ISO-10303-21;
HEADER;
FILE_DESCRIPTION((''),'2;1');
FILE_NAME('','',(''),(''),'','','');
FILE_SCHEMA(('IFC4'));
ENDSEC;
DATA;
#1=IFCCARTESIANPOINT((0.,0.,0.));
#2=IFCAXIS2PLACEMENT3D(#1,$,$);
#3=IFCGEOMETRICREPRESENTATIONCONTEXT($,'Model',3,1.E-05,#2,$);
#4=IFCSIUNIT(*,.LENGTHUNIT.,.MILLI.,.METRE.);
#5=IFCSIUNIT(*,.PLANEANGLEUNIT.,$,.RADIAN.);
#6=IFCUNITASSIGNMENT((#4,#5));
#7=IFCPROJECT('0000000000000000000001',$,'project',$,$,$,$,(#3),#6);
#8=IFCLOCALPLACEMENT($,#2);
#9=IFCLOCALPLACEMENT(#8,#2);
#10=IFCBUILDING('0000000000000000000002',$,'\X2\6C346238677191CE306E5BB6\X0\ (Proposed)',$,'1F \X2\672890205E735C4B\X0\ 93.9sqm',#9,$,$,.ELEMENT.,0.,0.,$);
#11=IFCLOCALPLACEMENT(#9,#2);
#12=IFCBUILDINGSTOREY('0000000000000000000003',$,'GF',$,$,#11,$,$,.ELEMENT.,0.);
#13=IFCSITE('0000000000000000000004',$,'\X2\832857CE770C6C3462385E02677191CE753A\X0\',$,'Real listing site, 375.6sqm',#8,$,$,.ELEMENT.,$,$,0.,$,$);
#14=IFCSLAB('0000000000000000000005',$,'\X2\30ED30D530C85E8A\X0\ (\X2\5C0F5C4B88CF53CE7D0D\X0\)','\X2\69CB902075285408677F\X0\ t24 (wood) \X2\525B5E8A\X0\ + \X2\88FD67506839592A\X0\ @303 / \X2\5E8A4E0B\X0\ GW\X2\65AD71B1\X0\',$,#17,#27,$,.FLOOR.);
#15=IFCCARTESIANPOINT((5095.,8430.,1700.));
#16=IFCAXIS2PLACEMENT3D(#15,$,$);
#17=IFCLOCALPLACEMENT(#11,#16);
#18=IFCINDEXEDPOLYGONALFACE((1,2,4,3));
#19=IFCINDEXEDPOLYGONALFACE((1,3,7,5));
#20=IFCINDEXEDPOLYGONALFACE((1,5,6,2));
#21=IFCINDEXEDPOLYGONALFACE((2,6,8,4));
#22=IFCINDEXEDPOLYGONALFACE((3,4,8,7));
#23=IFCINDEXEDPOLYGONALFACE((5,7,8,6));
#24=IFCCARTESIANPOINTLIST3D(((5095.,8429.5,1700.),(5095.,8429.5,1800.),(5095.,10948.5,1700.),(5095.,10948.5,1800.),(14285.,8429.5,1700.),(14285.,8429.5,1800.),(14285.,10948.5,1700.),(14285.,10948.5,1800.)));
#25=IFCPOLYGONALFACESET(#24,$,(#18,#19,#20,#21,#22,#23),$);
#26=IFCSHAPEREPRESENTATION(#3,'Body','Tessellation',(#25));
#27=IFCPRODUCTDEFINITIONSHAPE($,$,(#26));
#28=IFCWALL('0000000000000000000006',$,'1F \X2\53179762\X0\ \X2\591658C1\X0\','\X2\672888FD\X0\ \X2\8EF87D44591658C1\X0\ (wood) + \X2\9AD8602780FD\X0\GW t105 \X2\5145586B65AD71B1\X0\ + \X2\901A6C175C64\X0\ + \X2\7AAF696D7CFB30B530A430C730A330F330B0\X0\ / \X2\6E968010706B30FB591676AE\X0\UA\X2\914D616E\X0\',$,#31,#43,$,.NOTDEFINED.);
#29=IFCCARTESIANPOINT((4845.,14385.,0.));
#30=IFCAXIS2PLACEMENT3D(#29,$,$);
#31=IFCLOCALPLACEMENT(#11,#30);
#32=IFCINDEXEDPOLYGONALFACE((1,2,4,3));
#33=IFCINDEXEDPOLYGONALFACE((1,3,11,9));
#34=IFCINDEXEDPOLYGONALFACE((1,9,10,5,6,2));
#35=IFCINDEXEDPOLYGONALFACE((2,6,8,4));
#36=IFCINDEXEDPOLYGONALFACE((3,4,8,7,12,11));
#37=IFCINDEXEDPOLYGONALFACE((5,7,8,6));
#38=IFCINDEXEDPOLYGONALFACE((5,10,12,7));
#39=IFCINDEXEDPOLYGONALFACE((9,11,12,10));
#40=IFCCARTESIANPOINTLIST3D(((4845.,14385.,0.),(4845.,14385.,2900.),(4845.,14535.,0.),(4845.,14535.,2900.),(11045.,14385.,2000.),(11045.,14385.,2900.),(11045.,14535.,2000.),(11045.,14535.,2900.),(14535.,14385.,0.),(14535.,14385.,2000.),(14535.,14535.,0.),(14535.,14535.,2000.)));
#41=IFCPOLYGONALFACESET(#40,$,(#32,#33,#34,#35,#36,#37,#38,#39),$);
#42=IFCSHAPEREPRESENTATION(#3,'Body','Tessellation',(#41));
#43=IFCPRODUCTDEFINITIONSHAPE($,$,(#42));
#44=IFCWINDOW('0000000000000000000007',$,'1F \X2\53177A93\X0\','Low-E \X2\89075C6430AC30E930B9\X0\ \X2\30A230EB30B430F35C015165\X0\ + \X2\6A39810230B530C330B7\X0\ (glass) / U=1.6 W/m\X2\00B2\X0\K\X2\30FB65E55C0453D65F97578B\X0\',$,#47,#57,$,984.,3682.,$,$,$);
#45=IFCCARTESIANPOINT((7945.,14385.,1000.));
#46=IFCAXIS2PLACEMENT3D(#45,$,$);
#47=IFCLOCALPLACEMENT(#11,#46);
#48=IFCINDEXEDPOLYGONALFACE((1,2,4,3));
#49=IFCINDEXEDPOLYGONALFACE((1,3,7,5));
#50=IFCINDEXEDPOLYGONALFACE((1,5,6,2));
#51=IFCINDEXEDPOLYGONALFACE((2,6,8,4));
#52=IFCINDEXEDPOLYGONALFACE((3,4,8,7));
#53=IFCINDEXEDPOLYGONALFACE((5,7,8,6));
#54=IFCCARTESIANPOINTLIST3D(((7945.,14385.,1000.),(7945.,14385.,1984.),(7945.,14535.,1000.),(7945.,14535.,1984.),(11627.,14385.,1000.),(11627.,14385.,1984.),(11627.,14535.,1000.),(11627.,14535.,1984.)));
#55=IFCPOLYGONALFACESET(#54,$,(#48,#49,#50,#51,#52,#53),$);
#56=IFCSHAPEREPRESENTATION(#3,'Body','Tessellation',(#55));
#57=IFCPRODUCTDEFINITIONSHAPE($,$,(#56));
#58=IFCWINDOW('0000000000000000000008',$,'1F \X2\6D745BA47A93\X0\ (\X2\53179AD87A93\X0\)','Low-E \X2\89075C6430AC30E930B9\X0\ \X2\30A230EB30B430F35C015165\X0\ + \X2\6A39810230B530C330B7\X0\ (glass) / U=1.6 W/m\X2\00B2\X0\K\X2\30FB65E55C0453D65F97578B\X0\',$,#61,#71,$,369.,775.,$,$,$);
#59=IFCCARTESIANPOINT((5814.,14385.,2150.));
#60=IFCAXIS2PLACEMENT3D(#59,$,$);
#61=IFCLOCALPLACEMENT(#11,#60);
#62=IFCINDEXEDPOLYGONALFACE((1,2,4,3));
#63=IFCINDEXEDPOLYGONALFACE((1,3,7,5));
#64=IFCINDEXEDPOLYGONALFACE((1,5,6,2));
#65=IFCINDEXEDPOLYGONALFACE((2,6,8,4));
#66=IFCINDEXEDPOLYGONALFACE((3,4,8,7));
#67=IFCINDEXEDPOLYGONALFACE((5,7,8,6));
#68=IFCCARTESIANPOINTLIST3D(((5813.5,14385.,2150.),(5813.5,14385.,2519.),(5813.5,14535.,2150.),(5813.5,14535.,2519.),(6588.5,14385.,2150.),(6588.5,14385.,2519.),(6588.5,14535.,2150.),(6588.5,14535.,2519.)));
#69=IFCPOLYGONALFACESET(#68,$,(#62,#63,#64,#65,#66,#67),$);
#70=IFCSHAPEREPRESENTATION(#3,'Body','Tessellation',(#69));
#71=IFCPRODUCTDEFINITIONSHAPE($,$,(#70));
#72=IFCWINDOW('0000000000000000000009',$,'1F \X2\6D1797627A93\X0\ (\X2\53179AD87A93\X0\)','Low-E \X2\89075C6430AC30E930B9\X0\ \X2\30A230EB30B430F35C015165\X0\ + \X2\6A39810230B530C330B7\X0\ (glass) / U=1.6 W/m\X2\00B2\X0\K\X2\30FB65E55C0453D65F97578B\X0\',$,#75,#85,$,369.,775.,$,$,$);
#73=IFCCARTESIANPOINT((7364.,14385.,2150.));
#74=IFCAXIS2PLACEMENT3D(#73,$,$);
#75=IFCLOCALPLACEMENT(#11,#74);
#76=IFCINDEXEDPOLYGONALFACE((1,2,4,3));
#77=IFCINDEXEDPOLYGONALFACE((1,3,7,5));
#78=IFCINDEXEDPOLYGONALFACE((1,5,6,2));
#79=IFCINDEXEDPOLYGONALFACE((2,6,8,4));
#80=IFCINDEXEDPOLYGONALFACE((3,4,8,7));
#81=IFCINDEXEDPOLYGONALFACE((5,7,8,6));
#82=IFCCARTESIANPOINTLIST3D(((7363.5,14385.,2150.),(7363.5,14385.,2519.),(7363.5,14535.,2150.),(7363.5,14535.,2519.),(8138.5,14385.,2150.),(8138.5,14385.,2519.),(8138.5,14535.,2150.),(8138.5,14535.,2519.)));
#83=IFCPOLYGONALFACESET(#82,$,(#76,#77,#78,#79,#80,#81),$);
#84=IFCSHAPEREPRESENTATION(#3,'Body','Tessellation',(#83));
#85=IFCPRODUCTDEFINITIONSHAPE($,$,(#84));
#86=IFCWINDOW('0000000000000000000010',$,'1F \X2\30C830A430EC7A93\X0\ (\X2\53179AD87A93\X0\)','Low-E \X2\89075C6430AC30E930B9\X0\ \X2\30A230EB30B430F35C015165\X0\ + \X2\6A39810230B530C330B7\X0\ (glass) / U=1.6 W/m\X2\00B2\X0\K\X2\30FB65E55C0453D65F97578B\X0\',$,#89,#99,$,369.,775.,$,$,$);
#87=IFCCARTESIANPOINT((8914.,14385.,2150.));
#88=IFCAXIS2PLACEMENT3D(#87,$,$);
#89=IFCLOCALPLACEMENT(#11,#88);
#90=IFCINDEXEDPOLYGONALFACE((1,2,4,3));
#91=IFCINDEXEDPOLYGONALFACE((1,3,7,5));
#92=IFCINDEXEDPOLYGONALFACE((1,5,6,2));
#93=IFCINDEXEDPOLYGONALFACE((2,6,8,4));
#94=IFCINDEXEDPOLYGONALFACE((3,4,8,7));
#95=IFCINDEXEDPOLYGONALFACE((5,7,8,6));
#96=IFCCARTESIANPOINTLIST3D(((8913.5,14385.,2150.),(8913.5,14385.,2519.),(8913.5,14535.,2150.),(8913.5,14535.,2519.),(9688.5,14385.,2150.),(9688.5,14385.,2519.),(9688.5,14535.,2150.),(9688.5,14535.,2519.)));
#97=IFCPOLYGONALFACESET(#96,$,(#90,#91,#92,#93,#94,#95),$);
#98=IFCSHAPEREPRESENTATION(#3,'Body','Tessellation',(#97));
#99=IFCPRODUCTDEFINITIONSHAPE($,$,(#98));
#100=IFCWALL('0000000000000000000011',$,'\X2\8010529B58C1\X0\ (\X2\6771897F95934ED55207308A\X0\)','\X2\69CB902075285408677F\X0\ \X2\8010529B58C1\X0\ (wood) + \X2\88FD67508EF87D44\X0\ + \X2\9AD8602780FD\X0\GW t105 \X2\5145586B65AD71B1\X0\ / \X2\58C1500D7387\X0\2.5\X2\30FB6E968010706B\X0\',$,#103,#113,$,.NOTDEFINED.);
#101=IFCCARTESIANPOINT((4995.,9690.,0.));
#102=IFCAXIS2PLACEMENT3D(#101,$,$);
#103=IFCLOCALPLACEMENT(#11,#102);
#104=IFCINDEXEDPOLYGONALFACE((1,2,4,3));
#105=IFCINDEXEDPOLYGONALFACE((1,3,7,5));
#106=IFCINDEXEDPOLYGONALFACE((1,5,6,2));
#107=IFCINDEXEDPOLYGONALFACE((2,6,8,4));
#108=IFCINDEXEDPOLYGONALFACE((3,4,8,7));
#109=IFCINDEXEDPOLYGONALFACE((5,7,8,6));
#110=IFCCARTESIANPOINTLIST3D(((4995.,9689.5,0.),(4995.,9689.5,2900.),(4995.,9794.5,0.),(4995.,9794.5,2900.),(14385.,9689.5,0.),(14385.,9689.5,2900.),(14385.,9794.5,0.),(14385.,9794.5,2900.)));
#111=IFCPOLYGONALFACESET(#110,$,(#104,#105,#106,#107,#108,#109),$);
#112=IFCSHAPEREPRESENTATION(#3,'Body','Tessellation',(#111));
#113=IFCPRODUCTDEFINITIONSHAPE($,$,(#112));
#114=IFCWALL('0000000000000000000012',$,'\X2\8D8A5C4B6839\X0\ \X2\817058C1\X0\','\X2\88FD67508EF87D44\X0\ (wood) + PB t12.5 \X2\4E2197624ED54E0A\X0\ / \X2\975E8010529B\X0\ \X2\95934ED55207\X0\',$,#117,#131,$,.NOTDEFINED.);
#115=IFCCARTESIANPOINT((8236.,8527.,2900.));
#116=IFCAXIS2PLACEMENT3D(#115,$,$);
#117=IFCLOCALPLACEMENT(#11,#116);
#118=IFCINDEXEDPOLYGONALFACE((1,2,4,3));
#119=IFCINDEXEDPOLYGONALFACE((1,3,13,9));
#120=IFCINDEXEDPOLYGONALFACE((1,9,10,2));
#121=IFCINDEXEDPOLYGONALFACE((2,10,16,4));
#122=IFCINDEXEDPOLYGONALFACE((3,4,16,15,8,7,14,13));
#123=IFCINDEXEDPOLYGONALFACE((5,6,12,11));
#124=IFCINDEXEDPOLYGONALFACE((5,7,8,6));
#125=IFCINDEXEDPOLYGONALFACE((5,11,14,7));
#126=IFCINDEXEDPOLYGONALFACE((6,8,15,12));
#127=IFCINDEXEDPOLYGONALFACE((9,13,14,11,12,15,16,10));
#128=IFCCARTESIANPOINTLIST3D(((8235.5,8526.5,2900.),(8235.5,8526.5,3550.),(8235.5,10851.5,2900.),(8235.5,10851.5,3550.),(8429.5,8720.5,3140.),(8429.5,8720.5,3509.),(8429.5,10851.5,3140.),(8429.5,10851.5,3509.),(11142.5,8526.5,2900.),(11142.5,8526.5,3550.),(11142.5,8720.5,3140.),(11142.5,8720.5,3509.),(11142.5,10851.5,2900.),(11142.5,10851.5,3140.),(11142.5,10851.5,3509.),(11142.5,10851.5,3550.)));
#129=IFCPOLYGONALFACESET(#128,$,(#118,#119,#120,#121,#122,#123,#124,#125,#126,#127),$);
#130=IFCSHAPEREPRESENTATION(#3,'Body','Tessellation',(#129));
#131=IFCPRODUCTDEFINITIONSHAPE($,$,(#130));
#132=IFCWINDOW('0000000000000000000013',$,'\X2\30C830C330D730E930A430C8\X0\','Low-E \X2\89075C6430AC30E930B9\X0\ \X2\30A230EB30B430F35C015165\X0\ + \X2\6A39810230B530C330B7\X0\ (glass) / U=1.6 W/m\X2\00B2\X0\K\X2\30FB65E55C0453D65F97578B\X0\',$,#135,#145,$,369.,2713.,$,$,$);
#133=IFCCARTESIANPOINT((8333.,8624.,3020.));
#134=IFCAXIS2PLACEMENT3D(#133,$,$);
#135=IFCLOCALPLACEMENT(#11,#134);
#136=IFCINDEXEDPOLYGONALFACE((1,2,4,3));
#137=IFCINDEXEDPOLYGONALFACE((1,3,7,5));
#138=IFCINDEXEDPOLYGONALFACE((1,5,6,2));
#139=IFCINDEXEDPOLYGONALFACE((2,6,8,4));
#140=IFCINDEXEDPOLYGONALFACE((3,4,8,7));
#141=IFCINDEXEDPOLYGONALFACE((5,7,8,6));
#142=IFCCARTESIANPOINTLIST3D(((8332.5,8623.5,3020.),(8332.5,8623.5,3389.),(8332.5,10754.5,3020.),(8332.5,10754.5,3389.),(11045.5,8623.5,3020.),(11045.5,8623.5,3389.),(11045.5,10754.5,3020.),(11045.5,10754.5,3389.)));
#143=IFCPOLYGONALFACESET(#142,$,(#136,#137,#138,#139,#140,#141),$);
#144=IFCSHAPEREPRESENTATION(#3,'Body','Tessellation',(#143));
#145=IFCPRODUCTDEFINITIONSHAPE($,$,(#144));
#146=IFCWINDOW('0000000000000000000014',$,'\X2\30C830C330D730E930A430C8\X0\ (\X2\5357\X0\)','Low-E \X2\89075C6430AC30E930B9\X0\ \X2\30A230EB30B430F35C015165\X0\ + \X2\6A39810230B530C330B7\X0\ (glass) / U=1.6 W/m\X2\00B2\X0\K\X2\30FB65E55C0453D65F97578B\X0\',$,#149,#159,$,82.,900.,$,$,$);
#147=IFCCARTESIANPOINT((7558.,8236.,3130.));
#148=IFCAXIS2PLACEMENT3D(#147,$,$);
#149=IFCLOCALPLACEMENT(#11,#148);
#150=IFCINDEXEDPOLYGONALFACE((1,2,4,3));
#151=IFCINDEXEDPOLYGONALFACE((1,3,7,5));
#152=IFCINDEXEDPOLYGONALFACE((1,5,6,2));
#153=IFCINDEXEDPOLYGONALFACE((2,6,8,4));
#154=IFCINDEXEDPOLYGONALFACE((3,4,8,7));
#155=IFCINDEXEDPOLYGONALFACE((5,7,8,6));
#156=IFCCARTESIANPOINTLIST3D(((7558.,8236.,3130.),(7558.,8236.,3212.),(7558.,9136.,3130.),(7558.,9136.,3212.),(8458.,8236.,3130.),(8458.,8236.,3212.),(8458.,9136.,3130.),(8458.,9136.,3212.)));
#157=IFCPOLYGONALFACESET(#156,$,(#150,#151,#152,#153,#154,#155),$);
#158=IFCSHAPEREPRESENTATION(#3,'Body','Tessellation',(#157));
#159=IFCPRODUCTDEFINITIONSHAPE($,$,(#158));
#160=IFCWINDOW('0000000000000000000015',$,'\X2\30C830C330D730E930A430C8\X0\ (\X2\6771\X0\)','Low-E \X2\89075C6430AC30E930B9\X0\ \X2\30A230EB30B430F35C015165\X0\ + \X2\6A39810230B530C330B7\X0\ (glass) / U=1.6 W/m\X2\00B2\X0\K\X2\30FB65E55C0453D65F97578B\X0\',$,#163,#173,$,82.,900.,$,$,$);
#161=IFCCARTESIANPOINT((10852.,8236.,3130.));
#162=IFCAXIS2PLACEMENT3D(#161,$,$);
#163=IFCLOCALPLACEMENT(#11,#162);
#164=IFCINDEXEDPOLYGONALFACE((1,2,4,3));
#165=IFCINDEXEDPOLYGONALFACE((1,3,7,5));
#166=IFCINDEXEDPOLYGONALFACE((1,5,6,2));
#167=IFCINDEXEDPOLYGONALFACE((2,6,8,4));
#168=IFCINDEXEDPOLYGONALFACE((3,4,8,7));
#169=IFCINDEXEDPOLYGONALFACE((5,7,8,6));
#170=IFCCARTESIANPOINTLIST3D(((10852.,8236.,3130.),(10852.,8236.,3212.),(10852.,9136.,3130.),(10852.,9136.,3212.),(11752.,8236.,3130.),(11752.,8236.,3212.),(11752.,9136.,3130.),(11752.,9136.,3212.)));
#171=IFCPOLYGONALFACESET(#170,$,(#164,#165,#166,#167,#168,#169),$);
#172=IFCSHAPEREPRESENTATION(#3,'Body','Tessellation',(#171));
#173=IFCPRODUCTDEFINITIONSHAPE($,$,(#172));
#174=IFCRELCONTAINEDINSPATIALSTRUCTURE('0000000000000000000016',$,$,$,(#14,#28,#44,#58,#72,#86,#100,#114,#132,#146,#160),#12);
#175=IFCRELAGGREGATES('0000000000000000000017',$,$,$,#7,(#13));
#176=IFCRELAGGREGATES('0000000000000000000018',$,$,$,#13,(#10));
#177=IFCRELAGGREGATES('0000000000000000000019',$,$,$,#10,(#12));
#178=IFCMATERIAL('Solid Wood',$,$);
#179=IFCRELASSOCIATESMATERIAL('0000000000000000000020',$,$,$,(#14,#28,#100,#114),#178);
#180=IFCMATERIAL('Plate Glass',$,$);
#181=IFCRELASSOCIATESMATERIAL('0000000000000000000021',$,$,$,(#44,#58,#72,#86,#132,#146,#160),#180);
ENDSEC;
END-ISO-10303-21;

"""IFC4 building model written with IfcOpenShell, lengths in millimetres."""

from ifc_helpers import new_model, si_unit, frame, frame_2d, origin, place, context, project, spatial, rectangle, extrude, material, element, fill, save


model = new_model("IFC4")

# Units and contexts
model_context = context("Model", 3, precision=1e-05, world=origin())
ifc_project = project(units=[si_unit("LENGTHUNIT", "METRE", prefix="MILLI"), si_unit("PLANEANGLEUNIT", "RADIAN")], contexts=[model_context])

# Site, building, storey
site_placement = place(None, origin())
site = spatial("IfcSite", under=ifc_project, at=site_placement, Name="茨城県水戸市東野町", ObjectType="Real listing site, 375.6sqm", CompositionType="ELEMENT", RefElevation=0.0)
building_placement = place(site_placement, origin())
building = spatial("IfcBuilding", under=site, at=building_placement, Name="水戸東野の家 (Proposed)", ObjectType="1F 木造平屋 93.9sqm", CompositionType="ELEMENT", ElevationOfRefHeight=0.0, ElevationOfTerrain=0.0)
storey_placement = place(building_placement, origin())
storey = spatial("IfcBuildingStorey", under=building, at=storey_placement, Name="GF", CompositionType="ELEMENT", Elevation=0.0)

# Slab
ifc_material_1 = material(Name="Solid Wood")
slab_placement = place(storey_placement, frame((5095.0, 8430.0, 1700.0)))
element("IfcSlab", 1, at=slab_placement, inside=storey, material=ifc_material_1, Name="ロフト床 (小屋裏収納)", Description="構造用合板 t24 (wood) 剛床 + 製材根太 @303 / 床下 GW断熱", PredefinedType="FLOOR", context=model_context, shape_type="SweptSolid", body=[
    extrude(rectangle(XDim=9190.0, YDim=2519.0, at=frame_2d((4595.0, 1259.0))), frame((5095.0, 8430.0, 1700.0)), (0.0, 0.0, 1.0), 100.0),
])

# Wall, openings, windows
wall_1_placement = place(storey_placement, frame((4845.0, 14385.0, 0.0)))
wall_1 = element("IfcWall", 2, at=wall_1_placement, inside=storey, material=ifc_material_1, Name="1F 北面 外壁", Description="木製 軸組外壁 (wood) + 高性能GW t105 充填断熱 + 通気層 + 窯業系サイディング / 準耐火・外皮UA配慮", PredefinedType="NOTDEFINED", context=model_context, shape_type="SweptSolid", body=[
    extrude(rectangle(XDim=9690.0, YDim=150.0, at=frame_2d((4845.0, 75.0))), frame((4845.0, 14385.0, 0.0)), (0.0, 0.0, 1.0), 2900.0),
])
opening_1_placement = place(storey_placement, frame((7945.0, 14385.0, 1000.0)))
opening_1 = element("IfcOpeningElement", 3, at=opening_1_placement, cuts=wall_1, PredefinedType="NOTDEFINED", context=model_context, shape_type="SweptSolid", body=[
    extrude(rectangle(XDim=3682.0, YDim=150.0, at=frame_2d((1841.0, 75.0))), frame((7945.0, 14385.0, 1000.0)), (0.0, 0.0, 1.0), 984.0),
])
opening_2_placement = place(storey_placement, frame((5814.0, 14385.0, 2150.0)))
opening_2 = element("IfcOpeningElement", 4, at=opening_2_placement, cuts=wall_1, PredefinedType="NOTDEFINED", context=model_context, shape_type="SweptSolid", body=[
    extrude(rectangle(XDim=775.0, YDim=150.0, at=frame_2d((387.0, 75.0))), frame((5814.0, 14385.0, 2150.0)), (0.0, 0.0, 1.0), 369.0),
])
opening_3_placement = place(storey_placement, frame((7364.0, 14385.0, 2150.0)))
opening_3 = element("IfcOpeningElement", 5, at=opening_3_placement, cuts=wall_1, PredefinedType="NOTDEFINED", context=model_context, shape_type="SweptSolid", body=[
    extrude(rectangle(XDim=775.0, YDim=150.0, at=frame_2d((387.0, 75.0))), frame((7364.0, 14385.0, 2150.0)), (0.0, 0.0, 1.0), 369.0),
])
opening_4_placement = place(storey_placement, frame((8914.0, 14385.0, 2150.0)))
opening_4 = element("IfcOpeningElement", 6, at=opening_4_placement, cuts=wall_1, PredefinedType="NOTDEFINED", context=model_context, shape_type="SweptSolid", body=[
    extrude(rectangle(XDim=775.0, YDim=150.0, at=frame_2d((387.0, 75.0))), frame((8914.0, 14385.0, 2150.0)), (0.0, 0.0, 1.0), 369.0),
])
ifc_material_2 = material(Name="Plate Glass")
window_1_placement = place(storey_placement, frame((7945.0, 14385.0, 1000.0)))
window_1 = element("IfcWindow", 7, at=window_1_placement, inside=storey, material=ifc_material_2, Name="1F 北窓", Description="Low-E 複層ガラス アルゴン封入 + 樹脂サッシ (glass) / U=1.6 W/m²K・日射取得型", OverallHeight=984.0, OverallWidth=3682.0, context=model_context, shape_type="SweptSolid", body=[
    extrude(rectangle(XDim=3682.0, YDim=150.0, at=frame_2d((1841.0, 75.0))), frame((7945.0, 14385.0, 1000.0)), (0.0, 0.0, 1.0), 984.0),
])
fill(opening_1, window_1)
window_2_placement = place(storey_placement, frame((5814.0, 14385.0, 2150.0)))
window_2 = element("IfcWindow", 8, at=window_2_placement, inside=storey, material=ifc_material_2, Name="1F 浴室窓 (北高窓)", Description="Low-E 複層ガラス アルゴン封入 + 樹脂サッシ (glass) / U=1.6 W/m²K・日射取得型", OverallHeight=369.0, OverallWidth=775.0, context=model_context, shape_type="SweptSolid", body=[
    extrude(rectangle(XDim=775.0, YDim=150.0, at=frame_2d((387.0, 75.0))), frame((5814.0, 14385.0, 2150.0)), (0.0, 0.0, 1.0), 369.0),
])
fill(opening_2, window_2)
window_3_placement = place(storey_placement, frame((7364.0, 14385.0, 2150.0)))
window_3 = element("IfcWindow", 9, at=window_3_placement, inside=storey, material=ifc_material_2, Name="1F 洗面窓 (北高窓)", Description="Low-E 複層ガラス アルゴン封入 + 樹脂サッシ (glass) / U=1.6 W/m²K・日射取得型", OverallHeight=369.0, OverallWidth=775.0, context=model_context, shape_type="SweptSolid", body=[
    extrude(rectangle(XDim=775.0, YDim=150.0, at=frame_2d((387.0, 75.0))), frame((7364.0, 14385.0, 2150.0)), (0.0, 0.0, 1.0), 369.0),
])
fill(opening_3, window_3)
window_4_placement = place(storey_placement, frame((8914.0, 14385.0, 2150.0)))
window_4 = element("IfcWindow", 10, at=window_4_placement, inside=storey, material=ifc_material_2, Name="1F トイレ窓 (北高窓)", Description="Low-E 複層ガラス アルゴン封入 + 樹脂サッシ (glass) / U=1.6 W/m²K・日射取得型", OverallHeight=369.0, OverallWidth=775.0, context=model_context, shape_type="SweptSolid", body=[
    extrude(rectangle(XDim=775.0, YDim=150.0, at=frame_2d((387.0, 75.0))), frame((8914.0, 14385.0, 2150.0)), (0.0, 0.0, 1.0), 369.0),
])
fill(opening_4, window_4)

# Wall
wall_2_placement = place(storey_placement, frame((4995.0, 9690.0, 0.0)))
element("IfcWall", 11, at=wall_2_placement, inside=storey, material=ifc_material_1, Name="耐力壁 (東西間仕切り)", Description="構造用合板 耐力壁 (wood) + 製材軸組 + 高性能GW t105 充填断熱 / 壁倍率2.5・準耐火", PredefinedType="NOTDEFINED", context=model_context, shape_type="SweptSolid", body=[
    extrude(rectangle(XDim=9390.0, YDim=105.0, at=frame_2d((4695.0, 52.0))), frame((4995.0, 9690.0, 0.0)), (0.0, 0.0, 1.0), 2900.0),
])

# Wall, openings, windows
wall_3_placement = place(storey_placement, frame((8236.0, 8527.0, 2900.0)))
wall_3 = element("IfcWall", 12, at=wall_3_placement, inside=storey, material=ifc_material_1, Name="越屋根 腰壁", Description="製材軸組 (wood) + PB t12.5 両面仕上 / 非耐力 間仕切", PredefinedType="NOTDEFINED", context=model_context, shape_type="SweptSolid", body=[
    extrude(rectangle(XDim=2907.0, YDim=2325.0, at=frame_2d((1453.0, 1162.0))), frame((8236.0, 8527.0, 2900.0)), (0.0, 0.0, 1.0), 650.0),
])
opening_5_placement = place(storey_placement, frame((8333.0, 8624.0, 3020.0)))
opening_5 = element("IfcOpeningElement", 13, at=opening_5_placement, cuts=wall_3, PredefinedType="NOTDEFINED", context=model_context, shape_type="SweptSolid", body=[
    extrude(rectangle(XDim=2713.0, YDim=2131.0, at=frame_2d((1356.0, 1065.0))), frame((8333.0, 8624.0, 3020.0)), (0.0, 0.0, 1.0), 369.0),
])
opening_6_placement = place(storey_placement, frame((7558.0, 8236.0, 3130.0)))
opening_6 = element("IfcOpeningElement", 14, at=opening_6_placement, cuts=wall_3, PredefinedType="NOTDEFINED", context=model_context, shape_type="SweptSolid", body=[
    extrude(rectangle(XDim=900.0, YDim=900.0, at=frame_2d((450.0, 450.0))), frame((7558.0, 8236.0, 3130.0)), (0.0, 0.0, 1.0), 82.0),
])
opening_7_placement = place(storey_placement, frame((10852.0, 8236.0, 3130.0)))
opening_7 = element("IfcOpeningElement", 15, at=opening_7_placement, cuts=wall_3, PredefinedType="NOTDEFINED", context=model_context, shape_type="SweptSolid", body=[
    extrude(rectangle(XDim=900.0, YDim=900.0, at=frame_2d((450.0, 450.0))), frame((10852.0, 8236.0, 3130.0)), (0.0, 0.0, 1.0), 82.0),
])
window_5_placement = place(storey_placement, frame((8333.0, 8624.0, 3020.0)))
window_5 = element("IfcWindow", 16, at=window_5_placement, inside=storey, material=ifc_material_2, Name="トップライト", Description="Low-E 複層ガラス アルゴン封入 + 樹脂サッシ (glass) / U=1.6 W/m²K・日射取得型", OverallHeight=369.0, OverallWidth=2713.0, context=model_context, shape_type="SweptSolid", body=[
    extrude(rectangle(XDim=2713.0, YDim=2131.0, at=frame_2d((1356.0, 1065.0))), frame((8333.0, 8624.0, 3020.0)), (0.0, 0.0, 1.0), 369.0),
])
fill(opening_5, window_5)
window_6_placement = place(storey_placement, frame((7558.0, 8236.0, 3130.0)))
window_6 = element("IfcWindow", 17, at=window_6_placement, inside=storey, material=ifc_material_2, Name="トップライト (南)", Description="Low-E 複層ガラス アルゴン封入 + 樹脂サッシ (glass) / U=1.6 W/m²K・日射取得型", OverallHeight=82.0, OverallWidth=900.0, context=model_context, shape_type="SweptSolid", body=[
    extrude(rectangle(XDim=900.0, YDim=900.0, at=frame_2d((450.0, 450.0))), frame((7558.0, 8236.0, 3130.0)), (0.0, 0.0, 1.0), 82.0),
])
fill(opening_6, window_6)
window_7_placement = place(storey_placement, frame((10852.0, 8236.0, 3130.0)))
window_7 = element("IfcWindow", 18, at=window_7_placement, inside=storey, material=ifc_material_2, Name="トップライト (東)", Description="Low-E 複層ガラス アルゴン封入 + 樹脂サッシ (glass) / U=1.6 W/m²K・日射取得型", OverallHeight=82.0, OverallWidth=900.0, context=model_context, shape_type="SweptSolid", body=[
    extrude(rectangle(XDim=900.0, YDim=900.0, at=frame_2d((450.0, 450.0))), frame((10852.0, 8236.0, 3130.0)), (0.0, 0.0, 1.0), 82.0),
])
fill(opening_7, window_7)

save(model, "model.ifc")
